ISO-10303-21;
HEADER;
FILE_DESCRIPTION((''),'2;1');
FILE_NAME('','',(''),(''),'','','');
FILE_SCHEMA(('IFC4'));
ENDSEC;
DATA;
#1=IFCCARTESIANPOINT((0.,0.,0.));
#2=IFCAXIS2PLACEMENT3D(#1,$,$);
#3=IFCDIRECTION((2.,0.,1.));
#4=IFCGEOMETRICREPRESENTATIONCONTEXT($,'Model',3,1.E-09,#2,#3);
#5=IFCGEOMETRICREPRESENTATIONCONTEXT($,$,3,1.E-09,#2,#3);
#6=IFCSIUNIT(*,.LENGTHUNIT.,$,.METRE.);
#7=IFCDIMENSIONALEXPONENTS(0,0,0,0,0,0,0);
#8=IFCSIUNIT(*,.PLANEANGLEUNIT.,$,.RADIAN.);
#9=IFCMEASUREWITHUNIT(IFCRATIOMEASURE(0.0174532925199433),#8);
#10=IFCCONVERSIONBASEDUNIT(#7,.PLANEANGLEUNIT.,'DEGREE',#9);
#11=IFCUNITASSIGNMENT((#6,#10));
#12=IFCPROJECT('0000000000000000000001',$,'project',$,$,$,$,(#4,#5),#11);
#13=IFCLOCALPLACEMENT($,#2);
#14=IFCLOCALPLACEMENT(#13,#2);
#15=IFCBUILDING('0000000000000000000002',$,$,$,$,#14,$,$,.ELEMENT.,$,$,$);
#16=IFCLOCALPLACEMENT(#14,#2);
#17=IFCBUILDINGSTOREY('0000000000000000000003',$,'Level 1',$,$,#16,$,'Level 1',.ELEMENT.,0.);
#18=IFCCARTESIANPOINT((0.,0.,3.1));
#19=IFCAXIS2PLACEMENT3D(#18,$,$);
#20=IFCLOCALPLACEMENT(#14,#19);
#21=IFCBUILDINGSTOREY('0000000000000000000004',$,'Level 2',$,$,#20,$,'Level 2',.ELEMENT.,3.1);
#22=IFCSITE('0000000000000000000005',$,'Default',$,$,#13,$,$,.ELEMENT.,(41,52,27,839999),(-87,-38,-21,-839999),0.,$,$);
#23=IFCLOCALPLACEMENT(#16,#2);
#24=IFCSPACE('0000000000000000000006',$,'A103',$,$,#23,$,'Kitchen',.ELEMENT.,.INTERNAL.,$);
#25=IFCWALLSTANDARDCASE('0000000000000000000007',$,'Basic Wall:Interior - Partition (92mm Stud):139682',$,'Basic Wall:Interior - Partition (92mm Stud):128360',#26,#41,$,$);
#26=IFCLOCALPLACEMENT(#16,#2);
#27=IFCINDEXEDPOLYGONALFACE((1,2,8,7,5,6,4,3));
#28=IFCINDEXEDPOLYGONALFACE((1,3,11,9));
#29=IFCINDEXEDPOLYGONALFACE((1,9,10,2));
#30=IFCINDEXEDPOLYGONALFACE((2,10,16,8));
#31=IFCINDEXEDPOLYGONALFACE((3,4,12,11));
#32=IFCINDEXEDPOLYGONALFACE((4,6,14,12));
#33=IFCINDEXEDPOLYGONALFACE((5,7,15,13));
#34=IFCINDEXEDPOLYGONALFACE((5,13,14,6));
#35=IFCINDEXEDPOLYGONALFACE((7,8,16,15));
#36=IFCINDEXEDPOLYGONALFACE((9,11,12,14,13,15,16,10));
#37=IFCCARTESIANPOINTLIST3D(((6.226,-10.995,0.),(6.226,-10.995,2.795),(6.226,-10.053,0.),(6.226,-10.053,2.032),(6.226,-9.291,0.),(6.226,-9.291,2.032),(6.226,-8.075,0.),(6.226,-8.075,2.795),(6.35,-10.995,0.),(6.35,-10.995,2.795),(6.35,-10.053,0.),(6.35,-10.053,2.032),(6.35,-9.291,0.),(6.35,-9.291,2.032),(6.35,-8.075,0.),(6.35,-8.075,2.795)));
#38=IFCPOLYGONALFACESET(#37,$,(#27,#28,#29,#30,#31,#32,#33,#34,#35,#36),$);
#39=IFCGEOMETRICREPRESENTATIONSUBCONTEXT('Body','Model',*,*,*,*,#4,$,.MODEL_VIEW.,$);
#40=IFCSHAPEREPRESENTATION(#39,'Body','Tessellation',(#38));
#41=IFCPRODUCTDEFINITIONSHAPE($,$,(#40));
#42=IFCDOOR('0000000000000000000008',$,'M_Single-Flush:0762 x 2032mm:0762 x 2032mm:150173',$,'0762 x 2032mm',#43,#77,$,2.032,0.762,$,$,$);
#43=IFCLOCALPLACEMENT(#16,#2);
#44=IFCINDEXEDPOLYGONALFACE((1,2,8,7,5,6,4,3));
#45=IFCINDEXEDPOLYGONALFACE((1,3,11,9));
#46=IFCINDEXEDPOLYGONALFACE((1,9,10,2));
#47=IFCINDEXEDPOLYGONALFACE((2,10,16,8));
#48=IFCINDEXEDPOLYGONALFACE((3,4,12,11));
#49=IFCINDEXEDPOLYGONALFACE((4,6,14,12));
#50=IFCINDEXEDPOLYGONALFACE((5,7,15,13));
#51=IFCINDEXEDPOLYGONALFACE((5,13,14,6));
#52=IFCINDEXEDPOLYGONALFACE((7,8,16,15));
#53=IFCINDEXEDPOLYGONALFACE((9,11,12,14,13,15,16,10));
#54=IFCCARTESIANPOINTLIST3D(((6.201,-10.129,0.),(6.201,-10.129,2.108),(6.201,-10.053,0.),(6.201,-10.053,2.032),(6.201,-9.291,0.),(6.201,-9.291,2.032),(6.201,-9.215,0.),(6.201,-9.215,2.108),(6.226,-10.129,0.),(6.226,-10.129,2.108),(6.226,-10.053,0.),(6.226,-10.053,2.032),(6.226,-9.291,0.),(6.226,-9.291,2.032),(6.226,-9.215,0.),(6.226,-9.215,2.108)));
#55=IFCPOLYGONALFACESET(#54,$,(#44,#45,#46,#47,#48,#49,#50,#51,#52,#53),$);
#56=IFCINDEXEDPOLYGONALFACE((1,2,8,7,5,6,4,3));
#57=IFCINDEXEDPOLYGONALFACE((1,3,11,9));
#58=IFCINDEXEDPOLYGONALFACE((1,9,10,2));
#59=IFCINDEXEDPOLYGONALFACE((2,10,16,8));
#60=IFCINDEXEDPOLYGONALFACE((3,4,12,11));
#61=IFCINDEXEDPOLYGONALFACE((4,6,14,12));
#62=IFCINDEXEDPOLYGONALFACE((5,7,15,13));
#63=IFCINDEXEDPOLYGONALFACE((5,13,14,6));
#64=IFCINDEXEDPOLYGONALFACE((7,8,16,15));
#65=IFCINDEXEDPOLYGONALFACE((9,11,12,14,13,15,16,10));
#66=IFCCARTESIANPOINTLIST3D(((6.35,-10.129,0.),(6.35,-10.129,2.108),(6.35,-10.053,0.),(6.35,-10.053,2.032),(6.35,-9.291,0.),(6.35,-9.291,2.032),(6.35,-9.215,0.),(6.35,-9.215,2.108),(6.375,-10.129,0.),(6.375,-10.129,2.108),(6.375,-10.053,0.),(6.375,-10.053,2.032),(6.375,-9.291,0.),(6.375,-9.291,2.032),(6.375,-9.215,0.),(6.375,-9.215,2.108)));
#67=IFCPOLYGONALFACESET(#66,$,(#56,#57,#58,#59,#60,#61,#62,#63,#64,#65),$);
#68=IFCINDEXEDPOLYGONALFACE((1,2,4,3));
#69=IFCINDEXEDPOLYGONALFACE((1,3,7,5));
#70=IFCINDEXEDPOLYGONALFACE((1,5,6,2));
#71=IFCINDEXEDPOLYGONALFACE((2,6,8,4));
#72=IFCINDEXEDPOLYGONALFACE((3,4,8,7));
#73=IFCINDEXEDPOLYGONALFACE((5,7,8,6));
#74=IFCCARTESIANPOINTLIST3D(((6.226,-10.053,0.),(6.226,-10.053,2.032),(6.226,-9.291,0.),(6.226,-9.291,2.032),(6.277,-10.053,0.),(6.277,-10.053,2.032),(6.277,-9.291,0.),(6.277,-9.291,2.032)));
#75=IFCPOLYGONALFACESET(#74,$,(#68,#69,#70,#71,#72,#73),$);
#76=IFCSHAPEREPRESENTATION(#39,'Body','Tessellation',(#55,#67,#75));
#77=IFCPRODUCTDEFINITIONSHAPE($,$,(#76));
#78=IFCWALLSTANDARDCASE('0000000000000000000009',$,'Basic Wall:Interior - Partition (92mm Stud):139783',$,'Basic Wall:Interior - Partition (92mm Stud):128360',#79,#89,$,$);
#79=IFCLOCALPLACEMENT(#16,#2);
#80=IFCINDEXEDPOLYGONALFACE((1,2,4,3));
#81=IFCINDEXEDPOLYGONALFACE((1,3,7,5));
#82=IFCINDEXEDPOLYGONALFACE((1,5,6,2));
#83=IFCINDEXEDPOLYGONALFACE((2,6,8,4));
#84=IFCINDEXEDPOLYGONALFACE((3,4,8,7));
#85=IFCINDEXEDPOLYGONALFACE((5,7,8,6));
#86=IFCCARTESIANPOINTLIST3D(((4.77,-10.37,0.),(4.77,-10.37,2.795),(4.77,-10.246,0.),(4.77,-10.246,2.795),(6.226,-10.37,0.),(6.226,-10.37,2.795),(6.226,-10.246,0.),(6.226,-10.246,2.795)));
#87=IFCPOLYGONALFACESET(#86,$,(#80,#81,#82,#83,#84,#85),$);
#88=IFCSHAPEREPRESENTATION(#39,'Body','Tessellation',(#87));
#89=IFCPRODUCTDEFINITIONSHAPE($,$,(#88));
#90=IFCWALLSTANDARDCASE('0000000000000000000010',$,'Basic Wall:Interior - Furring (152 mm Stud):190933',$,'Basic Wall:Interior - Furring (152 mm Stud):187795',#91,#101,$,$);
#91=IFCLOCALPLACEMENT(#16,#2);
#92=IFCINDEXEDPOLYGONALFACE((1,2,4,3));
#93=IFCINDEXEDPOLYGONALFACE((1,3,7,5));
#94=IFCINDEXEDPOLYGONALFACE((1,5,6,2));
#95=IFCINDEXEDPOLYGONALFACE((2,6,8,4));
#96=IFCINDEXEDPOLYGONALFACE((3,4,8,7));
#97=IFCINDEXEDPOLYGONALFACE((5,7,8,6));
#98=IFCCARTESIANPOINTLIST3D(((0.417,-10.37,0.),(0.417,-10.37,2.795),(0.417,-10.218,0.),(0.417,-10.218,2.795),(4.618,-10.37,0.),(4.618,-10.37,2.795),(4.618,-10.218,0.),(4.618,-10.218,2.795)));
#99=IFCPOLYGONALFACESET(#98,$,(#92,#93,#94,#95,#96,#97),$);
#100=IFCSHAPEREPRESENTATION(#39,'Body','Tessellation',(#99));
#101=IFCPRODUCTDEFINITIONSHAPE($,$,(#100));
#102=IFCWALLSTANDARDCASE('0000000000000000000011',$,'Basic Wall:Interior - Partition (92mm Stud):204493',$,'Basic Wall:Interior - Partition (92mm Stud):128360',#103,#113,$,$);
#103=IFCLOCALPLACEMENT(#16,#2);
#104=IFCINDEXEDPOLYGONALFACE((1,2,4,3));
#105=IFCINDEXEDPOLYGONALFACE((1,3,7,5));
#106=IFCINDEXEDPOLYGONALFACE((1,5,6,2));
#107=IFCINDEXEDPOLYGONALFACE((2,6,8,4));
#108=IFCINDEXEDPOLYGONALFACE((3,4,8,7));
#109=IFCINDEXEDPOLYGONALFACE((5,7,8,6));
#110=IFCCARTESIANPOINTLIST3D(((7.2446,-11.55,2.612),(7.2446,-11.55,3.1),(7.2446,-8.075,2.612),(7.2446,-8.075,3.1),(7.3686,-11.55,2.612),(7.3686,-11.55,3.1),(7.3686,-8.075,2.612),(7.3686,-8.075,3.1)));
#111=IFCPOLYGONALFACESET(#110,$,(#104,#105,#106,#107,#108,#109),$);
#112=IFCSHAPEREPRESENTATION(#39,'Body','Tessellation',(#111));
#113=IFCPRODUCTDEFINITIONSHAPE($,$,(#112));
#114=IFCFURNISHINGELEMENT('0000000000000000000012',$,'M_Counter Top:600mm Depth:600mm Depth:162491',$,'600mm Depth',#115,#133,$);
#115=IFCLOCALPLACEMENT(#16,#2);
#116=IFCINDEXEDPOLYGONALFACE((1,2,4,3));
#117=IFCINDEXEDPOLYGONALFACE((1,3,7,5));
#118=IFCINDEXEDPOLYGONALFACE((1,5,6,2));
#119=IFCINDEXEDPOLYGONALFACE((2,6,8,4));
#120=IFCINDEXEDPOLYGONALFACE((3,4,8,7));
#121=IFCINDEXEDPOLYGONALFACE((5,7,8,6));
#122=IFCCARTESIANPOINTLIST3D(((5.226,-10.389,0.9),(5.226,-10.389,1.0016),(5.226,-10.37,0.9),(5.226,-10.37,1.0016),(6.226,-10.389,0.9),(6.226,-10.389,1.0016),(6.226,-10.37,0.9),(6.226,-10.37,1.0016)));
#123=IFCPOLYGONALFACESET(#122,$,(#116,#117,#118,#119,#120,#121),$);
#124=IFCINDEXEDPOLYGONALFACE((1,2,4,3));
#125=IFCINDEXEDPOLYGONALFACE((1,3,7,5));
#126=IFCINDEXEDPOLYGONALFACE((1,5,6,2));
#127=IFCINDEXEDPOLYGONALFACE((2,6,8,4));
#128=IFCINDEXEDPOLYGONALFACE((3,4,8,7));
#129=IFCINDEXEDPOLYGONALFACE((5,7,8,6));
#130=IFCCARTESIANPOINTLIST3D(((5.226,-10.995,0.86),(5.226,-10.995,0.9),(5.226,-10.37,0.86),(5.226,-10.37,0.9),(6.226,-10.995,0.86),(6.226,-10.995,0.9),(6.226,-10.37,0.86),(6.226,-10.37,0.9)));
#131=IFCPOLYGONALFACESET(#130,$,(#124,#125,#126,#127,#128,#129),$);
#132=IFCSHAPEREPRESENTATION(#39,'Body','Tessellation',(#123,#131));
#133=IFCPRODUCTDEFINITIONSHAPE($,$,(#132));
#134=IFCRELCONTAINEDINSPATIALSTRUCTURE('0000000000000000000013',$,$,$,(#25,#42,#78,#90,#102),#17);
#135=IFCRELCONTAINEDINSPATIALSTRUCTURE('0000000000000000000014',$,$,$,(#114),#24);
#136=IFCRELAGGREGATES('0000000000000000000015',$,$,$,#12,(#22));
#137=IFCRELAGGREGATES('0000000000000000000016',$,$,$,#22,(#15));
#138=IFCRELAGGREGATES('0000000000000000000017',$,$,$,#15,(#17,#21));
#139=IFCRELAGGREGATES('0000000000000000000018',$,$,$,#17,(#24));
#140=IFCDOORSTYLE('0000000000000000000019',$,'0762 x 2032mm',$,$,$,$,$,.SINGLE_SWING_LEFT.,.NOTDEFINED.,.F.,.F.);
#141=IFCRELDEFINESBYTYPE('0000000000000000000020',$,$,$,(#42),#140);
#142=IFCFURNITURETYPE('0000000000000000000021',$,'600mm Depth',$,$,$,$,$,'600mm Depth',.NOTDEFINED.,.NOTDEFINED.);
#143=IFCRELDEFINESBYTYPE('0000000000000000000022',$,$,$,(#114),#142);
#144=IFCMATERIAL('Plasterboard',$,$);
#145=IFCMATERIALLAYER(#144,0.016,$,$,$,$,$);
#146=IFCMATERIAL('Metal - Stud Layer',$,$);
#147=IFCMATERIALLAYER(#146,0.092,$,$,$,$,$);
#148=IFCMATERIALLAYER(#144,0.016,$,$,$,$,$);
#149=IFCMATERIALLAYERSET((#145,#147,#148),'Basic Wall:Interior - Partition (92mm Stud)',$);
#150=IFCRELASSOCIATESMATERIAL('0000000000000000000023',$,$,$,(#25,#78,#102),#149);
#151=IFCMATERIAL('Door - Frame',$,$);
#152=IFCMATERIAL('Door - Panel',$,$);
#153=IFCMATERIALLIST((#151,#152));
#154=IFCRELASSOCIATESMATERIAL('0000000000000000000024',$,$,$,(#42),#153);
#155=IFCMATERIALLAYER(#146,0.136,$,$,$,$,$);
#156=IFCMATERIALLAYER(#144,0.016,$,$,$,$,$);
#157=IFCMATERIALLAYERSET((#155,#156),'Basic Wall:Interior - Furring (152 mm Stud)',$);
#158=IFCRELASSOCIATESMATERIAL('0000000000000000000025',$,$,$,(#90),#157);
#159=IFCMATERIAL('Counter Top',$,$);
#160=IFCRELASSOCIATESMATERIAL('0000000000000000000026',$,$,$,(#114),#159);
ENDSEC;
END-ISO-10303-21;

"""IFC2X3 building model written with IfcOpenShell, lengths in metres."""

from ifc_helpers import new_model, entity, si_unit, converted_unit, direction, frame, frame_2d, origin, place, context, subcontext, project, spatial, polyline, rectangle, outline, extrude, source, transform, mapped, material, material_list, layer, layer_set, layer_usage, type_object, type_shapes, element, fill, save


model = new_model("IFC2X3")

# Units and contexts
model_context = context("Model", 3, precision=1e-09, world=origin(), true_north=direction((2.0, 0.0, 1.0)))
context_of_model = context(None, 3, precision=1e-09, world=origin(), true_north=direction((2.0, 0.0, 1.0)))
body_context = subcontext(model_context, "Body", "Model", "MODEL_VIEW")
ifc_project = project(units=[si_unit("LENGTHUNIT", "METRE"), converted_unit("PLANEANGLEUNIT", "DEGREE", entity("IfcRatioMeasure", 0.0174532925199433), si_unit("PLANEANGLEUNIT", "RADIAN"), dimensions=[0, 0, 0, 0, 0, 0, 0])], contexts=[model_context, context_of_model])

# Site, building, storey
site_placement = place(None, origin())
site = spatial("IfcSite", under=ifc_project, at=site_placement, Name="Default", CompositionType="ELEMENT", RefLatitude=(41, 52, 27, 839999), RefLongitude=(-87, -38, -21, -839999), RefElevation=0.0)
building_placement = place(site_placement, origin())
building = spatial("IfcBuilding", under=site, at=building_placement, CompositionType="ELEMENT")
storey_1_placement = place(building_placement, origin())
storey_1 = spatial("IfcBuildingStorey", under=building, at=storey_1_placement, Name="Level 1", LongName="Level 1", CompositionType="ELEMENT", Elevation=0.0)

# Shared definitions
ifc_material_1 = material(Name="Plasterboard")
ifc_material_2 = material(Name="Metal - Stud Layer")

# Wall, opening, door
ifc_layer_1 = layer(ifc_material_1, 0.016)
ifc_layer_2 = layer(ifc_material_2, 0.092)
ifc_layer_3 = layer(ifc_material_1, 0.016)
ifc_layer_set_1 = layer_set([ifc_layer_1, ifc_layer_2, ifc_layer_3], Name="Basic Wall:Interior - Partition (92mm Stud)")
ifc_layer_usage_1 = layer_usage(ifc_layer_set_1, "AXIS2", "NEGATIVE", 0.062)
wall_1_placement = place(storey_1_placement, frame((6.288, -10.995, 0.0), z_axis=(0.0, 0.0, 1.0), x_axis=(0.0, 1.0, 0.0)))
wall_1 = element("IfcWallStandardCase", 1, at=wall_1_placement, inside=storey_1, material=ifc_layer_usage_1, Name="Basic Wall:Interior - Partition (92mm Stud):139682", ObjectType="Basic Wall:Interior - Partition (92mm Stud):128360", context=body_context, shape_type="SweptSolid", body=[
    extrude(rectangle(XDim=2.92, YDim=0.124, at=frame_2d((1.46, 0.0), x_axis=(-1.0, 0.0))), origin(), (0.0, 0.0, 1.0), 2.795),
])
opening_1_placement = place(wall_1_placement, frame((0.942, -0.062, 0.0)))
opening_1 = element("IfcOpeningElement", 2, at=opening_1_placement, cuts=wall_1, ObjectType="Opening", context=body_context, shape_type="SweptSolid", body=[
    extrude(rectangle(XDim=0.762, YDim=2.032, at=frame_2d((1.016, 0.381), x_axis=(0.0, -1.0))), frame((0.0, 0.0, 0.0), z_axis=(0.0, 1.0, 0.0), x_axis=(0.0, 0.0, 1.0)), (0.0, 0.0, 1.0), 0.124),
])
ifc_material_3 = material(Name="Door - Frame")
ifc_material_4 = material(Name="Door - Panel")
ifc_material_list_1 = material_list([ifc_material_3, ifc_material_4])
door_style_1 = type_object("IfcDoorStyle", Name="0762 x 2032mm", ConstructionType="NOTDEFINED", OperationType="SINGLE_SWING_LEFT", ParameterTakesPrecedence=False, Sizeable=False)
shared_shape_1 = source(origin(), body_context, "Body", "SweptSolid", [
    extrude(outline(polyline([(-0.457, -1.073), (0.457, -1.073), (0.457, 1.035), (0.381, 1.035), (0.381, -0.997), (-0.381, -0.997), (-0.381, 1.035), (-0.457, 1.035), (-0.457, -1.073)])), frame((0.381, 0.149, 1.035), z_axis=(0.0, -1.0, 0.0), x_axis=(-1.0, 0.0, 0.0)), (0.0, 0.0, 1.0), 0.025),
    extrude(outline(polyline([(-1.073, -0.457), (1.035, -0.457), (1.035, -0.381), (-0.997, -0.381), (-0.997, 0.381), (1.035, 0.381), (1.035, 0.457), (-1.073, 0.457), (-1.073, -0.457)])), frame((0.381, 0.0, 1.035), z_axis=(0.0, -1.0, 0.0), x_axis=(0.0, 0.0, -1.0)), (0.0, 0.0, 1.0), 0.025),
    extrude(rectangle(XDim=0.762, YDim=0.051, at=frame_2d((0.0, 0.0), x_axis=(1.0, 0.0))), frame((0.381, 0.0985, 0.0)), (0.0, 0.0, 1.0), 2.032),
])
type_shapes(door_style_1, [shared_shape_1])
door_1_placement = place(opening_1_placement, origin())
door_1 = element("IfcDoor", 3, at=door_1_placement, inside=storey_1, type_object=door_style_1, material=ifc_material_list_1, Name="M_Single-Flush:0762 x 2032mm:0762 x 2032mm:150173", ObjectType="0762 x 2032mm", OverallHeight=2.032, OverallWidth=0.762, context=body_context, shape_type="MappedRepresentation", body=[
    mapped(shared_shape_1, transform((0.0, 0.0, 0.0), scale=1.0)),
])
fill(opening_1, door_1)

# Wall
ifc_layer_usage_2 = layer_usage(ifc_layer_set_1, "AXIS2", "NEGATIVE", 0.062)
wall_2_placement = place(storey_1_placement, frame((4.77, -10.308, 0.0)))
element("IfcWallStandardCase", 4, at=wall_2_placement, inside=storey_1, material=ifc_layer_usage_2, Name="Basic Wall:Interior - Partition (92mm Stud):139783", ObjectType="Basic Wall:Interior - Partition (92mm Stud):128360", context=body_context, shape_type="SweptSolid", body=[
    extrude(rectangle(XDim=1.456, YDim=0.124, at=frame_2d((0.728, 0.0), x_axis=(-1.0, 0.0))), origin(), (0.0, 0.0, 1.0), 2.795),
])

# Shared definitions
storey_2_placement = place(building_placement, frame((0.0, 0.0, 3.1)))
storey_2 = spatial("IfcBuildingStorey", under=building, at=storey_2_placement, Name="Level 2", LongName="Level 2", CompositionType="ELEMENT", Elevation=3.1)

# Walls
ifc_layer_4 = layer(ifc_material_2, 0.136)
ifc_layer_5 = layer(ifc_material_1, 0.016)
ifc_layer_set_2 = layer_set([ifc_layer_4, ifc_layer_5], Name="Basic Wall:Interior - Furring (152 mm Stud)")
ifc_layer_usage_3 = layer_usage(ifc_layer_set_2, "AXIS2", "NEGATIVE", 0.076)
wall_3_placement = place(storey_1_placement, frame((0.417, -10.294, 0.0)))
element("IfcWallStandardCase", 5, at=wall_3_placement, inside=storey_1, material=ifc_layer_usage_3, Name="Basic Wall:Interior - Furring (152 mm Stud):190933", ObjectType="Basic Wall:Interior - Furring (152 mm Stud):187795", context=body_context, shape_type="SweptSolid", body=[
    extrude(rectangle(XDim=4.201, YDim=0.152, at=frame_2d((2.1005, 0.0), x_axis=(-1.0, 0.0))), origin(), (0.0, 0.0, 1.0), 2.795),
])
ifc_layer_usage_4 = layer_usage(ifc_layer_set_1, "AXIS2", "NEGATIVE", 0.062)
wall_4_placement = place(storey_1_placement, frame((7.3066, -11.55, 2.612), z_axis=(0.0, 0.0, 1.0), x_axis=(0.0, 1.0, 0.0)))
element("IfcWallStandardCase", 6, at=wall_4_placement, inside=storey_1, material=ifc_layer_usage_4, Name="Basic Wall:Interior - Partition (92mm Stud):204493", ObjectType="Basic Wall:Interior - Partition (92mm Stud):128360", context=body_context, shape_type="SweptSolid", body=[
    extrude(rectangle(XDim=3.475, YDim=0.124, at=frame_2d((1.7375, 0.0), x_axis=(-1.0, 0.0))), origin(), (0.0, 0.0, 1.0), 0.488),
])

# Shared definitions
space_placement = place(storey_1_placement, origin())
space = spatial("IfcSpace", under=storey_1, at=space_placement, Name="A103", LongName="Kitchen", CompositionType="ELEMENT", InteriorOrExteriorSpace="INTERNAL")

# Furnishing element
ifc_material_5 = material(Name="Counter Top")
furniture_type_1 = type_object("IfcFurnitureType", Name="600mm Depth", ElementType="600mm Depth", AssemblyPlace="NOTDEFINED")
shared_shape_2 = source(origin(), body_context, "Body", "SweptSolid", [
    extrude(rectangle(XDim=0.0191, YDim=1.0, at=frame_2d((0.0, 0.0), x_axis=(1.0, 0.0))), frame((-0.7005, -0.0095, 0.9), z_axis=(0.0, 0.0, 1.0), x_axis=(0.0, -1.0, 0.0)), (0.0, 0.0, 1.0), 0.1016),
    extrude(rectangle(XDim=1.0, YDim=0.625, at=frame_2d((0.0, 0.0), x_axis=(1.0, 0.0))), frame((-0.7005, -0.3125, 0.86), z_axis=(0.0, 0.0, 1.0), x_axis=(-1.0, 0.0, 0.0)), (0.0, 0.0, 1.0), 0.04),
])
type_shapes(furniture_type_1, [shared_shape_2])
furnishing_1_placement = place(space_placement, frame((6.4265, -10.37, 0.0)))
element("IfcFurnishingElement", 7, at=furnishing_1_placement, inside=space, type_object=furniture_type_1, material=ifc_material_5, Name="M_Counter Top:600mm Depth:600mm Depth:162491", ObjectType="600mm Depth", context=body_context, shape_type="MappedRepresentation", body=[
    mapped(shared_shape_2, transform((0.0, 0.0, 0.0), scale=1.0)),
])

save(model, "model.ifc")
